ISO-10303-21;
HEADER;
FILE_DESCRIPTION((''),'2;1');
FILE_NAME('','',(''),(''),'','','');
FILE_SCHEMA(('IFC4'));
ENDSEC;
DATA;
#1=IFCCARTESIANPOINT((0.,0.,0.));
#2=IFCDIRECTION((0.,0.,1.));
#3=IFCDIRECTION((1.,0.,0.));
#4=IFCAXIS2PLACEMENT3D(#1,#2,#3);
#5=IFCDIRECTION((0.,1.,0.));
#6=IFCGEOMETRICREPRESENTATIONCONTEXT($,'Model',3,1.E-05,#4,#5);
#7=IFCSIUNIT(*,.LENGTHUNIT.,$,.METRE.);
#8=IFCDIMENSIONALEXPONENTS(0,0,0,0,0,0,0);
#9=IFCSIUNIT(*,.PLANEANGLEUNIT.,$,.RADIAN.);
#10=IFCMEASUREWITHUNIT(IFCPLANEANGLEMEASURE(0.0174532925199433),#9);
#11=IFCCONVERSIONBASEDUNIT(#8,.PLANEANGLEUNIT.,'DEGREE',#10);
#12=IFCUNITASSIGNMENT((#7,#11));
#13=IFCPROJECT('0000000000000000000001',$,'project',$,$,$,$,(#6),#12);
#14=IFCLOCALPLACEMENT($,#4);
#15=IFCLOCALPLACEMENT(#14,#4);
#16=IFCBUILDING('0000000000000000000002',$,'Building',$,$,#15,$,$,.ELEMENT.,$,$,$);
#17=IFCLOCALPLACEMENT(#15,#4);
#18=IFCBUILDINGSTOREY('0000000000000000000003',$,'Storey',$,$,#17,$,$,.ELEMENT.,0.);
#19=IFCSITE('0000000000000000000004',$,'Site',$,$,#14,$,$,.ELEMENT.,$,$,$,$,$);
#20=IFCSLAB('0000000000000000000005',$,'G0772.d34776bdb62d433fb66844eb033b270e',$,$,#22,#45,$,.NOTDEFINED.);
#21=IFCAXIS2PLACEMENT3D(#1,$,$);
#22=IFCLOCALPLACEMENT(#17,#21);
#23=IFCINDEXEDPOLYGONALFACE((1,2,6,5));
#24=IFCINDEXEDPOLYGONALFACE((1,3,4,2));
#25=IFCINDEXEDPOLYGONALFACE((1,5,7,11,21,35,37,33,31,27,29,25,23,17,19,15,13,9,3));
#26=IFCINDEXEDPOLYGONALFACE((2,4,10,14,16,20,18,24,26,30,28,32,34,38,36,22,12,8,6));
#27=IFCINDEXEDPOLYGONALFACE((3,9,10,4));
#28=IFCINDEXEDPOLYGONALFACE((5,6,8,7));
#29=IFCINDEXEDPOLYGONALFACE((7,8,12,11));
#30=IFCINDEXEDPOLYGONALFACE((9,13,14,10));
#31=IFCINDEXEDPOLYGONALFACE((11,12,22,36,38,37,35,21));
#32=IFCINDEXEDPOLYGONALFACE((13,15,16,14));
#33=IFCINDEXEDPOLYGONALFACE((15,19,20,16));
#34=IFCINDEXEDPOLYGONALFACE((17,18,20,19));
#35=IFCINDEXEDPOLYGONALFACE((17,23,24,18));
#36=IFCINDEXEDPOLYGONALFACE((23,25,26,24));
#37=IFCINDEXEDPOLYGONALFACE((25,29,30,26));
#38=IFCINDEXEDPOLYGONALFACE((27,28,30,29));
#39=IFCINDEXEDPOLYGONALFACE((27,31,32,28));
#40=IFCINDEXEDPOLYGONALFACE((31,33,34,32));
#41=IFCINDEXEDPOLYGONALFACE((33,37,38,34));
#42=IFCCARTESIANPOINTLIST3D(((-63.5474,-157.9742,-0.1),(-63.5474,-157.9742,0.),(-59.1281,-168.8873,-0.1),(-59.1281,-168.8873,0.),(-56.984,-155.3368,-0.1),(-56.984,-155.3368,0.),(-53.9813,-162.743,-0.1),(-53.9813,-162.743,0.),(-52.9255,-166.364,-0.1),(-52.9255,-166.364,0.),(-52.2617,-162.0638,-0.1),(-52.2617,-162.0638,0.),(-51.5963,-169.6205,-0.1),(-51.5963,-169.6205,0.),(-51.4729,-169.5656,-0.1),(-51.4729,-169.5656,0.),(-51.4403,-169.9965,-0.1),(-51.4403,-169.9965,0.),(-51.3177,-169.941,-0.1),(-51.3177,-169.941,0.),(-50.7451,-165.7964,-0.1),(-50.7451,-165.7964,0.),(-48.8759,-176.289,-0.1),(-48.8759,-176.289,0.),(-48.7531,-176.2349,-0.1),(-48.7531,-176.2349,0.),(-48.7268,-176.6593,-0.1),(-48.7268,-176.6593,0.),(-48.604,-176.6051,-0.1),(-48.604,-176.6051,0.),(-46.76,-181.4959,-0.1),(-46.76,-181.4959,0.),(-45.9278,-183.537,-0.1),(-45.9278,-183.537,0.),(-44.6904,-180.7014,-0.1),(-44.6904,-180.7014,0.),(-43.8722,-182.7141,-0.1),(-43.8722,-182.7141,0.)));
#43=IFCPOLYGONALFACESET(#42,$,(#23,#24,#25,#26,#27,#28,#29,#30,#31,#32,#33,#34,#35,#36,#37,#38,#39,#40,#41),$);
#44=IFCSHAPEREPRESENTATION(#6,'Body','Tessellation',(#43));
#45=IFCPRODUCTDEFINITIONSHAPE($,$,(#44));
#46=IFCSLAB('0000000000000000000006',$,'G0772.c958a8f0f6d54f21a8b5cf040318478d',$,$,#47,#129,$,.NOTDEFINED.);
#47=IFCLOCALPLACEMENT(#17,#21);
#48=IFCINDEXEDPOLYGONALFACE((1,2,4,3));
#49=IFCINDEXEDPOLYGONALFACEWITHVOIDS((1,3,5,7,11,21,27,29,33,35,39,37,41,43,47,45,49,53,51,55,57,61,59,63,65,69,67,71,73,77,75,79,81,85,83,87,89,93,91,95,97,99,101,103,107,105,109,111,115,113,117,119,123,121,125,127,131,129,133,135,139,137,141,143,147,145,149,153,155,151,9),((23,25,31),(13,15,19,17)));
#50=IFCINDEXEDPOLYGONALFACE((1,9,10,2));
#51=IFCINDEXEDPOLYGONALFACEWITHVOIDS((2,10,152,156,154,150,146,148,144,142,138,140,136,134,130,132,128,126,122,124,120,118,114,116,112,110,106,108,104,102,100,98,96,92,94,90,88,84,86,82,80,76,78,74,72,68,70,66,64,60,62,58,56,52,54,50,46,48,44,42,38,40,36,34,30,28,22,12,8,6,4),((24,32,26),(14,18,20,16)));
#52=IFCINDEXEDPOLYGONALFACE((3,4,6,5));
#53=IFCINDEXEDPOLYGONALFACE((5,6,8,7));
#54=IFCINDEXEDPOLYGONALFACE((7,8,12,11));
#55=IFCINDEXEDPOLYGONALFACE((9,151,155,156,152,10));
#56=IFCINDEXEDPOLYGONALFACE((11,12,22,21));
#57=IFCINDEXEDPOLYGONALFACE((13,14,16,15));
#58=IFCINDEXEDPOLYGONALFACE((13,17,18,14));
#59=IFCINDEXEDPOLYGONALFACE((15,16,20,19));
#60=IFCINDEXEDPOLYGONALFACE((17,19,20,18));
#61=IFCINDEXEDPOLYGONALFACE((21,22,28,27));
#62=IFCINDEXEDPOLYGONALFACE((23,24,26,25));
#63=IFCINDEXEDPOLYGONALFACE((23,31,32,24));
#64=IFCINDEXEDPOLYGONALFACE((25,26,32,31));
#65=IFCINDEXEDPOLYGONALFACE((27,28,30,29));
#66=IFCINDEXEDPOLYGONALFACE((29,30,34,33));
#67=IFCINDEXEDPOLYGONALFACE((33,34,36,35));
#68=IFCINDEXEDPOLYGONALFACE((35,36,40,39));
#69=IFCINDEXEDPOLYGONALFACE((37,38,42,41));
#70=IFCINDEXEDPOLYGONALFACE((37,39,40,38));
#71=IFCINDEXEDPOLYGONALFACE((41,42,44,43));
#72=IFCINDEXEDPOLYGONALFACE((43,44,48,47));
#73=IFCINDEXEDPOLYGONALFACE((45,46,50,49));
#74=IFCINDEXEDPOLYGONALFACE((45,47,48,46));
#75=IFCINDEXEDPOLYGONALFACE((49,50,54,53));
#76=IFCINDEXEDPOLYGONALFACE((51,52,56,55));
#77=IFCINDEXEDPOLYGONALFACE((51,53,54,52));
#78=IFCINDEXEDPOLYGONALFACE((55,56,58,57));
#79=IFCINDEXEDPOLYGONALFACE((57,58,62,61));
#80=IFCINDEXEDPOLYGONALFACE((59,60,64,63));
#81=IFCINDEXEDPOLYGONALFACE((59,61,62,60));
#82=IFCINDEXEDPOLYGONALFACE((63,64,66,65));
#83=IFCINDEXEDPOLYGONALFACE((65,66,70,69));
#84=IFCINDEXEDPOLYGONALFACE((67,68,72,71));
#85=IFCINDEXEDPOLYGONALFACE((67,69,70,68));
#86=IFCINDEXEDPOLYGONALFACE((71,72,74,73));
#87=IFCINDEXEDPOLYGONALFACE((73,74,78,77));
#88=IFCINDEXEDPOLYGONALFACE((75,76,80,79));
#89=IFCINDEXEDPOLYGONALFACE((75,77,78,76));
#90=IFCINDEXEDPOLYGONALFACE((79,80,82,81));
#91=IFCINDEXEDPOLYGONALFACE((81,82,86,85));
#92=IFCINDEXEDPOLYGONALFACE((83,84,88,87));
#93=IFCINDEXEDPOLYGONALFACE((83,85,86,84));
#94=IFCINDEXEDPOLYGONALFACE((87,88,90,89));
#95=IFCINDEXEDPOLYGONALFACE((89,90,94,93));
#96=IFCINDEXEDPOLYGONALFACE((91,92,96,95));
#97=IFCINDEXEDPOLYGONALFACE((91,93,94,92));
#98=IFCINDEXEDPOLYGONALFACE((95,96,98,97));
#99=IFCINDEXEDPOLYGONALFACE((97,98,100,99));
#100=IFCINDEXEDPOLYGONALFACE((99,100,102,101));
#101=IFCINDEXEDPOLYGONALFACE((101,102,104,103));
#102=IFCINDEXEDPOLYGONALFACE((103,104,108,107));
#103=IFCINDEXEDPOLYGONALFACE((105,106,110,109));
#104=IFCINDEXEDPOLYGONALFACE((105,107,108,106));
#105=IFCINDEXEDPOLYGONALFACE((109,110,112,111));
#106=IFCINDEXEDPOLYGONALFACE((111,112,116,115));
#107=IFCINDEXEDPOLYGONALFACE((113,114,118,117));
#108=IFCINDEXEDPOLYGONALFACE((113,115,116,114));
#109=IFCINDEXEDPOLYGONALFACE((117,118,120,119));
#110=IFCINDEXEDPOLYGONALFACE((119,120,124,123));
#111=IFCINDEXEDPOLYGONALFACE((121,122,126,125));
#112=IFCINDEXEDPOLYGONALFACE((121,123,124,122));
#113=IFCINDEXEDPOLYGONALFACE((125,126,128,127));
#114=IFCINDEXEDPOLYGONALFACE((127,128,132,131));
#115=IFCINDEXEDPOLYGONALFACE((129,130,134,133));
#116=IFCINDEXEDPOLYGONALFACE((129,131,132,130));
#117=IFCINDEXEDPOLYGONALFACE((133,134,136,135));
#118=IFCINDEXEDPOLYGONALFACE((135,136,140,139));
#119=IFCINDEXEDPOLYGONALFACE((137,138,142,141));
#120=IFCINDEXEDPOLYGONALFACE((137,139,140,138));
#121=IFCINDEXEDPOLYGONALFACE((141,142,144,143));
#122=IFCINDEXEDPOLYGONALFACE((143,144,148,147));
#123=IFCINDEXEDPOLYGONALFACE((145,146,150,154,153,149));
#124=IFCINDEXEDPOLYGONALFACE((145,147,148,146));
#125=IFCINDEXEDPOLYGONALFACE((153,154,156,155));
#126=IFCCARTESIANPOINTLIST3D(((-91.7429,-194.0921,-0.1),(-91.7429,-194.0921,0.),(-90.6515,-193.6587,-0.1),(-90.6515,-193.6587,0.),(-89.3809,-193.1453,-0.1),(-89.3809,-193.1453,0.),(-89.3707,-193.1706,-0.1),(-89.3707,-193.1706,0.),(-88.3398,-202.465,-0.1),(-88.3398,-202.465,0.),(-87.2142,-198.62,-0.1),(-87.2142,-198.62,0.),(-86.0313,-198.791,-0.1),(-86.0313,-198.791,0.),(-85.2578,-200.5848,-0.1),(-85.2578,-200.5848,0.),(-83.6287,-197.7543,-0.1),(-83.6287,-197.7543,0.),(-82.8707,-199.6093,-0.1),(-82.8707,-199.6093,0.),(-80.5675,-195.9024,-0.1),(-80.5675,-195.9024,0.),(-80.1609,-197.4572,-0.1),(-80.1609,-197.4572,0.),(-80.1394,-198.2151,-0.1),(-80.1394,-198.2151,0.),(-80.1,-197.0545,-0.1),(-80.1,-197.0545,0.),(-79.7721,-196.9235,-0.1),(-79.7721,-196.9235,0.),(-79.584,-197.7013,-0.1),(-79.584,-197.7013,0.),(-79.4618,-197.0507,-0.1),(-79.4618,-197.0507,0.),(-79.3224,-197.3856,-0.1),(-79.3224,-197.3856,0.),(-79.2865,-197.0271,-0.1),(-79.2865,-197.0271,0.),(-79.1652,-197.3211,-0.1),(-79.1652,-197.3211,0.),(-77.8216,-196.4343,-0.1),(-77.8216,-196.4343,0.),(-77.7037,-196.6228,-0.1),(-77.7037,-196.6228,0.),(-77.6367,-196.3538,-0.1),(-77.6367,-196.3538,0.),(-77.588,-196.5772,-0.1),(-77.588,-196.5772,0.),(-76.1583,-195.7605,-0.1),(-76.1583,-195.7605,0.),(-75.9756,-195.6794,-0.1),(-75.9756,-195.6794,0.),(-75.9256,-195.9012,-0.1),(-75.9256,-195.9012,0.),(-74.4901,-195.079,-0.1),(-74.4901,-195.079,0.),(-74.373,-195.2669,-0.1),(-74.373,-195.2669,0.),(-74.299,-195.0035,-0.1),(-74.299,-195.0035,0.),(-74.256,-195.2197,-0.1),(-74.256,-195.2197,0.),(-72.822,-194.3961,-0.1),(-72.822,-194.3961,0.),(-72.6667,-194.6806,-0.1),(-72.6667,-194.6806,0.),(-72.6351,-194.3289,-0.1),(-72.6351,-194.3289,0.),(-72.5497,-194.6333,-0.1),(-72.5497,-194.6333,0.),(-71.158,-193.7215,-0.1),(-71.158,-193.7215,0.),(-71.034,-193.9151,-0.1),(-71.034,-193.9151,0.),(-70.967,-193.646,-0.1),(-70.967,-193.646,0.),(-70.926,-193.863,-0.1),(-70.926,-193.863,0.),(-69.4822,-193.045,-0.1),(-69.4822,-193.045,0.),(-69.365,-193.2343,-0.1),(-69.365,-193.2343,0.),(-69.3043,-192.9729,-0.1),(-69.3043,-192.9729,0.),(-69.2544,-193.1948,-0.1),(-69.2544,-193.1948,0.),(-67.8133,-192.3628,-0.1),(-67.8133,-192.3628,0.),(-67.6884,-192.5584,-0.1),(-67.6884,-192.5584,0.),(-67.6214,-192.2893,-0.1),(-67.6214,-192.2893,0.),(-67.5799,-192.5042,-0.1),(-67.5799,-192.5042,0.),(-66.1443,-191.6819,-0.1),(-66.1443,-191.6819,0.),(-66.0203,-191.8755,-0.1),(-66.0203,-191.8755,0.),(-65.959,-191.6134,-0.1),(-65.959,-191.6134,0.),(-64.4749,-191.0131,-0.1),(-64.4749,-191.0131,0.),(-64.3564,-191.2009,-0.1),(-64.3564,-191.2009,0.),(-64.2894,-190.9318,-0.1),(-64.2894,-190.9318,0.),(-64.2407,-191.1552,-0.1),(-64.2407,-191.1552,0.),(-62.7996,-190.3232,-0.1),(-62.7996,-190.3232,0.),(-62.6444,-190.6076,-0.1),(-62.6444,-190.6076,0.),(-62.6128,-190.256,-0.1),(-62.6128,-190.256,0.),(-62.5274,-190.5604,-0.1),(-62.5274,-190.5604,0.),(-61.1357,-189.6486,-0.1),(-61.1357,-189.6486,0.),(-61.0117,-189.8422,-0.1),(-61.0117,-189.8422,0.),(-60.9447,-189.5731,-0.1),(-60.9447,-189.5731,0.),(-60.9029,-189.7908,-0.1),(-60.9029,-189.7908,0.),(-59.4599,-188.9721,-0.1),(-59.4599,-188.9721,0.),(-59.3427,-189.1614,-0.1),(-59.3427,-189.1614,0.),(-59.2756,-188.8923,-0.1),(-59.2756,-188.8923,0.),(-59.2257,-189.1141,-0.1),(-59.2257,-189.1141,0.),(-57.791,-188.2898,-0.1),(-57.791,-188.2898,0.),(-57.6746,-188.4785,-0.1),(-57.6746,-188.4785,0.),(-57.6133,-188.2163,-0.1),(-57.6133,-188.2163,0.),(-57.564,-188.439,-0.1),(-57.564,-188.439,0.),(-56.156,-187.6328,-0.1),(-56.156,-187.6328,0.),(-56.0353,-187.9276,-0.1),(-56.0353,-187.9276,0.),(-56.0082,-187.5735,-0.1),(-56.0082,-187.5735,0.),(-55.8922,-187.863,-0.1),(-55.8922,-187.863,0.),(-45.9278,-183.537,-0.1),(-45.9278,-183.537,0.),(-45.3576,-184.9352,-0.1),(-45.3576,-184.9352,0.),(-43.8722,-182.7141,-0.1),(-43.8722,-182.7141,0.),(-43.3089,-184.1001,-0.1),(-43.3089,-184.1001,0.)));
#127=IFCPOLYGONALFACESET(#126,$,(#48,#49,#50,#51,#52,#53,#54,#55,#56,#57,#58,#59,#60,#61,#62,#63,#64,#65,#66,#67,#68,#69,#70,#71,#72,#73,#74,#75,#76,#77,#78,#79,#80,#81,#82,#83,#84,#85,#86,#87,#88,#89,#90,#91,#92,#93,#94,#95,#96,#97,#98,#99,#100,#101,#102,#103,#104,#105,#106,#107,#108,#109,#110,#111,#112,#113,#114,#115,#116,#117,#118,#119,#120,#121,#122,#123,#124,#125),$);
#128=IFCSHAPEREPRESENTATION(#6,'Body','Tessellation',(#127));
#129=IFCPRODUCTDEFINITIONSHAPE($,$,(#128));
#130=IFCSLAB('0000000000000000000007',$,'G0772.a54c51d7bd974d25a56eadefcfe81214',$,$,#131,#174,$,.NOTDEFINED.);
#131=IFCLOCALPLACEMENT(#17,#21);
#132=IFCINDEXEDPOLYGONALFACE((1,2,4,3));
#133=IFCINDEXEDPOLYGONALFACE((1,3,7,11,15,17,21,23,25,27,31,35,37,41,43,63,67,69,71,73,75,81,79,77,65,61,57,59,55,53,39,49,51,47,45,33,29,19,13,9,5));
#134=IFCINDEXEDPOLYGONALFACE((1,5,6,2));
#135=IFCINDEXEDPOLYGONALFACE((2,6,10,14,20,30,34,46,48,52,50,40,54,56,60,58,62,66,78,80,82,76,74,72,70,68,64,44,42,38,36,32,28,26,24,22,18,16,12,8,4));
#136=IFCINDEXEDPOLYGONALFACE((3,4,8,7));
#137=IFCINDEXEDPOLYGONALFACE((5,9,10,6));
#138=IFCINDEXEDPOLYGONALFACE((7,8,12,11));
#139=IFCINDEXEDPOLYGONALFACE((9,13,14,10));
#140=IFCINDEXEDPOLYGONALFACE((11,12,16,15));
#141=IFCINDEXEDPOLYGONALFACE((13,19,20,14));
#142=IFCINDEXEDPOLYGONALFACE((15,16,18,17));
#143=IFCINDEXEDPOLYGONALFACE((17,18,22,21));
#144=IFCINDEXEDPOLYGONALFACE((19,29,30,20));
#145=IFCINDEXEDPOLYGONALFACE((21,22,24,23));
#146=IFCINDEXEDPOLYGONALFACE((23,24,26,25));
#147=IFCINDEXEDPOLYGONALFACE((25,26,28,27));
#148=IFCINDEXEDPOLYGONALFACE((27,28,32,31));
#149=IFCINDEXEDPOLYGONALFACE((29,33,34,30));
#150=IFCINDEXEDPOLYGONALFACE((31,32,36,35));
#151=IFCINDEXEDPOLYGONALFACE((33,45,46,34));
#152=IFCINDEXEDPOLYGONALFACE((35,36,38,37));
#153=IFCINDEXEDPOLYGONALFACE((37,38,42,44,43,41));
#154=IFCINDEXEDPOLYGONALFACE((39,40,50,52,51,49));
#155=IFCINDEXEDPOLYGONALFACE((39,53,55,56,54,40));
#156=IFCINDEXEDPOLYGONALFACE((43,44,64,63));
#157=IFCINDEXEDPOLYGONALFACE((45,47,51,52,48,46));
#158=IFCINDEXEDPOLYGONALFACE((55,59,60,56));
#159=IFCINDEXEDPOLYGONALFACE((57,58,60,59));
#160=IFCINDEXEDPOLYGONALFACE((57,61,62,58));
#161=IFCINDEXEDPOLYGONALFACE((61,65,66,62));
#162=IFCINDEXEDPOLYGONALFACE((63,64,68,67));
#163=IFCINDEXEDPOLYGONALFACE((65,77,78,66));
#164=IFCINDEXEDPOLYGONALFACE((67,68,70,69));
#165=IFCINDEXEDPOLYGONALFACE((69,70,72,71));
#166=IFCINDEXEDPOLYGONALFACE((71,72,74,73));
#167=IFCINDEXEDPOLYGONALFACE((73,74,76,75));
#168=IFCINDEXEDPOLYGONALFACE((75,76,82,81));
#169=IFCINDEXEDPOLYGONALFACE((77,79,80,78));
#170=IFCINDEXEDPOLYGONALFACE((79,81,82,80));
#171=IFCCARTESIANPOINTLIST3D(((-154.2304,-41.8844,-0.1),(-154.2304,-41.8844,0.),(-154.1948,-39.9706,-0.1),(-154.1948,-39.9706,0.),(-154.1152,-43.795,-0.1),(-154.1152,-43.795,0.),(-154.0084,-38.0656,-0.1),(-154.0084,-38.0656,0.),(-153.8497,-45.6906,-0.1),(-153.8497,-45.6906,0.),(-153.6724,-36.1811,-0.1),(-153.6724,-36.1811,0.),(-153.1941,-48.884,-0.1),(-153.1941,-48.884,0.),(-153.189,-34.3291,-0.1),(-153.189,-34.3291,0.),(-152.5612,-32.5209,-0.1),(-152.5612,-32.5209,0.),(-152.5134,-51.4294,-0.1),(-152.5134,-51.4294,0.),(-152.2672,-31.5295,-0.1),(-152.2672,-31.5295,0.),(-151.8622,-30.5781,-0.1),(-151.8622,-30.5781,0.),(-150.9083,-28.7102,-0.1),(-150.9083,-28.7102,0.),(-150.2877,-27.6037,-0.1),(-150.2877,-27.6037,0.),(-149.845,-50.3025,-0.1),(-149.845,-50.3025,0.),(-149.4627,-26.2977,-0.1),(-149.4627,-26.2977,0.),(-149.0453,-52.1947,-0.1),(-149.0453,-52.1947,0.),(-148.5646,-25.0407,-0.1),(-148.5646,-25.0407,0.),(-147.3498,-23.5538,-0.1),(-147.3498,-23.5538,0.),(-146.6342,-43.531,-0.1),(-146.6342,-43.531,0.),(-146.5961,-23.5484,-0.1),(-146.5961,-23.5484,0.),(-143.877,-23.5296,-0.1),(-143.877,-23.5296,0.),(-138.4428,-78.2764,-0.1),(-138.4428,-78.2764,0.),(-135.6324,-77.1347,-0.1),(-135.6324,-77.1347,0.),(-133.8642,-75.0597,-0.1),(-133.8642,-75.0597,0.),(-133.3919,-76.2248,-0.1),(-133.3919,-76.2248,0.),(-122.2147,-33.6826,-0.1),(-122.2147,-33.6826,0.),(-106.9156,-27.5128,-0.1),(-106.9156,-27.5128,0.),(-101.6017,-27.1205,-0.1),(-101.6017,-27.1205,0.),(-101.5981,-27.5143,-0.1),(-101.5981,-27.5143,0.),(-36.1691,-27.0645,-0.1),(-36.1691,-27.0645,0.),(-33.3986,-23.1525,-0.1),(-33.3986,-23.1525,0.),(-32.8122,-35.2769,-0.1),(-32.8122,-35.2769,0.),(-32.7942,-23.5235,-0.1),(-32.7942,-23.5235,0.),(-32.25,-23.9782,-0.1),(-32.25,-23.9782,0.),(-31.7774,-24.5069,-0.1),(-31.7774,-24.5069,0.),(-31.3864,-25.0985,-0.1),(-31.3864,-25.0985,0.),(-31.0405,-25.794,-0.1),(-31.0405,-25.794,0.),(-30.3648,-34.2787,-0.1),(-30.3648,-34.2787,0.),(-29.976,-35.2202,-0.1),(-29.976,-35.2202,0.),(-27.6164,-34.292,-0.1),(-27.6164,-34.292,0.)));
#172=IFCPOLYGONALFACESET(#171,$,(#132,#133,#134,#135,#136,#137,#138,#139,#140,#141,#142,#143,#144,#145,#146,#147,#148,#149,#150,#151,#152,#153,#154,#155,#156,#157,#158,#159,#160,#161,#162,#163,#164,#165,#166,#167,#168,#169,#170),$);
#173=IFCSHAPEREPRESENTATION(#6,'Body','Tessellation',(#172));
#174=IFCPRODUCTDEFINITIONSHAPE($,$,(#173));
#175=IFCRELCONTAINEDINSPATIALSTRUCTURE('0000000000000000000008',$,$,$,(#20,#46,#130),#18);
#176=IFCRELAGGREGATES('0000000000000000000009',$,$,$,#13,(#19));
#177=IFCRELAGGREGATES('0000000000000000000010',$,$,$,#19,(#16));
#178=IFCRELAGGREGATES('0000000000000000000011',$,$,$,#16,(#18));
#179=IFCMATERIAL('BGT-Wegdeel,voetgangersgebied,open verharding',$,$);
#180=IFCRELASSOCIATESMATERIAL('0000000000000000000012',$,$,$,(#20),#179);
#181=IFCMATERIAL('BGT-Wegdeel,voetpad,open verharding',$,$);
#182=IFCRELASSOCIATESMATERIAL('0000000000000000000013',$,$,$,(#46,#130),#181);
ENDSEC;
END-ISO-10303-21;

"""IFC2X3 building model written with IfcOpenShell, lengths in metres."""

from ifc_helpers import new_model, entity, si_unit, converted_unit, direction, frame, origin_with_axes, place, context, project, spatial, polyline, outline, extrude, material, element, save


model = new_model("IFC2X3")

# Units and contexts
model_context = context("Model", 3, precision=1e-05, world=origin_with_axes(), true_north=direction((0.0, 1.0, 0.0)))
ifc_project = project(units=[si_unit("LENGTHUNIT", "METRE"), converted_unit("PLANEANGLEUNIT", "DEGREE", entity("IfcPlaneAngleMeasure", 0.0174532925199433), si_unit("PLANEANGLEUNIT", "RADIAN"), dimensions=[0, 0, 0, 0, 0, 0, 0])], contexts=[model_context])

# Site, building, storey
site_placement = place(None, origin_with_axes())
site = spatial("IfcSite", under=ifc_project, at=site_placement, Name="Site", CompositionType="ELEMENT")
building_placement = place(site_placement, origin_with_axes())
building = spatial("IfcBuilding", under=site, at=building_placement, Name="Building", CompositionType="ELEMENT")
storey_placement = place(building_placement, origin_with_axes())
storey = spatial("IfcBuildingStorey", under=building, at=storey_placement, Name="Storey", CompositionType="ELEMENT", Elevation=0.0)

# Slabs
ifc_material_1 = material(Name="BGT-Wegdeel,voetpad,open verharding")
ifc_material_2 = material(Name="BGT-Wegdeel,voetgangersgebied,open verharding")
slab_1_placement = place(storey_placement, frame((0.0, 0.0, -0.1), z_axis=(0.0, 0.0, 1.0), x_axis=(1.0, 0.0, 0.0)))
element("IfcSlab", 1, at=slab_1_placement, inside=storey, material=ifc_material_2, Name="G0772.d34776bdb62d433fb66844eb033b270e", PredefinedType="NOTDEFINED", context=model_context, shape_type="SweptSolid", body=[
    extrude(outline(polyline([(-53.9813, -162.743), (-52.2617, -162.0638), (-50.7451, -165.7964), (-44.6904, -180.7014), (-43.8722, -182.7141), (-45.9278, -183.537), (-46.76, -181.4959), (-48.7268, -176.6593), (-48.604, -176.6051), (-48.7531, -176.2349), (-48.8759, -176.289), (-51.4403, -169.9965), (-51.3177, -169.941), (-51.4729, -169.5656), (-51.5963, -169.6205), (-52.9255, -166.364), (-59.1281, -168.8873), (-63.5474, -157.9742), (-56.984, -155.3368), (-53.9813, -162.743)])), origin_with_axes(), (0.0, 0.0, 1.0), 0.1),
])
slab_2_placement = place(storey_placement, frame((0.0, 0.0, -0.1), z_axis=(0.0, 0.0, 1.0), x_axis=(1.0, 0.0, 0.0)))
element("IfcSlab", 2, at=slab_2_placement, inside=storey, material=ifc_material_1, Name="G0772.c958a8f0f6d54f21a8b5cf040318478d", PredefinedType="NOTDEFINED", context=model_context, shape_type="SweptSolid", body=[
    extrude(outline(polyline([(-45.9278, -183.537), (-43.8722, -182.7141), (-43.3089, -184.1001), (-45.3576, -184.9352), (-88.3398, -202.465), (-91.7429, -194.0921), (-90.6515, -193.6587), (-89.3809, -193.1453), (-89.3707, -193.1706), (-87.2142, -198.62), (-80.5675, -195.9024), (-80.1, -197.0545), (-79.7721, -196.9235), (-79.4618, -197.0507), (-79.3224, -197.3856), (-79.1652, -197.3211), (-79.2865, -197.0271), (-77.8216, -196.4343), (-77.7037, -196.6228), (-77.588, -196.5772), (-77.6367, -196.3538), (-76.1583, -195.7605), (-75.9256, -195.9012), (-75.9756, -195.6794), (-74.4901, -195.079), (-74.373, -195.2669), (-74.256, -195.2197), (-74.299, -195.0035), (-72.822, -194.3961), (-72.6667, -194.6806), (-72.5497, -194.6333), (-72.6351, -194.3289), (-71.158, -193.7215), (-71.034, -193.9151), (-70.926, -193.863), (-70.967, -193.646), (-69.4822, -193.045), (-69.365, -193.2343), (-69.2544, -193.1948), (-69.3043, -192.9729), (-67.8133, -192.3628), (-67.6884, -192.5584), (-67.5799, -192.5042), (-67.6214, -192.2893), (-66.1443, -191.6819), (-66.0203, -191.8755), (-65.959, -191.6134), (-64.4749, -191.0131), (-64.3564, -191.2009), (-64.2407, -191.1552), (-64.2894, -190.9318), (-62.7996, -190.3232), (-62.6444, -190.6076), (-62.5274, -190.5604), (-62.6128, -190.256), (-61.1357, -189.6486), (-61.0117, -189.8422), (-60.9029, -189.7908), (-60.9447, -189.5731), (-59.4599, -188.9721), (-59.3427, -189.1614), (-59.2257, -189.1141), (-59.2756, -188.8923), (-57.791, -188.2898), (-57.6746, -188.4785), (-57.564, -188.439), (-57.6133, -188.2163), (-56.156, -187.6328), (-56.0353, -187.9276), (-55.8922, -187.863), (-56.0082, -187.5735), (-45.9278, -183.537)]), holes=[polyline([(-83.6287, -197.7543), (-86.0313, -198.791), (-85.2578, -200.5848), (-82.8707, -199.6093), (-83.6287, -197.7543)]), polyline([(-80.1609, -197.4572), (-80.1394, -198.2151), (-79.584, -197.7013), (-80.1609, -197.4572)])]), origin_with_axes(), (0.0, 0.0, 1.0), 0.1),
])
slab_3_placement = place(storey_placement, frame((0.0, 0.0, -0.1), z_axis=(0.0, 0.0, 1.0), x_axis=(1.0, 0.0, 0.0)))
element("IfcSlab", 3, at=slab_3_placement, inside=storey, material=ifc_material_1, Name="G0772.a54c51d7bd974d25a56eadefcfe81214", PredefinedType="NOTDEFINED", context=model_context, shape_type="SweptSolid", body=[
    extrude(outline(polyline([(-33.3986, -23.1525), (-32.7942, -23.5235), (-32.25, -23.9782), (-31.7774, -24.5069), (-31.3864, -25.0985), (-31.0405, -25.794), (-27.6164, -34.292), (-29.976, -35.2202), (-30.3648, -34.2787), (-32.8122, -35.2769), (-36.1691, -27.0645), (-101.6017, -27.1205), (-101.5981, -27.5143), (-106.9156, -27.5128), (-122.2147, -33.6826), (-146.6342, -43.531), (-133.8642, -75.0597), (-133.3919, -76.2248), (-135.6324, -77.1347), (-138.4428, -78.2764), (-149.0453, -52.1947), (-149.845, -50.3025), (-152.5134, -51.4294), (-153.1941, -48.884), (-153.8497, -45.6906), (-154.1152, -43.795), (-154.2304, -41.8844), (-154.1948, -39.9706), (-154.0084, -38.0656), (-153.6724, -36.1811), (-153.189, -34.3291), (-152.5612, -32.5209), (-152.2672, -31.5295), (-151.8622, -30.5781), (-150.9083, -28.7102), (-150.2877, -27.6037), (-149.4627, -26.2977), (-148.5646, -25.0407), (-147.3498, -23.5538), (-146.5961, -23.5484), (-143.877, -23.5296), (-33.3986, -23.1525)])), origin_with_axes(), (0.0, 0.0, 1.0), 0.1),
])

save(model, "model.ifc")
